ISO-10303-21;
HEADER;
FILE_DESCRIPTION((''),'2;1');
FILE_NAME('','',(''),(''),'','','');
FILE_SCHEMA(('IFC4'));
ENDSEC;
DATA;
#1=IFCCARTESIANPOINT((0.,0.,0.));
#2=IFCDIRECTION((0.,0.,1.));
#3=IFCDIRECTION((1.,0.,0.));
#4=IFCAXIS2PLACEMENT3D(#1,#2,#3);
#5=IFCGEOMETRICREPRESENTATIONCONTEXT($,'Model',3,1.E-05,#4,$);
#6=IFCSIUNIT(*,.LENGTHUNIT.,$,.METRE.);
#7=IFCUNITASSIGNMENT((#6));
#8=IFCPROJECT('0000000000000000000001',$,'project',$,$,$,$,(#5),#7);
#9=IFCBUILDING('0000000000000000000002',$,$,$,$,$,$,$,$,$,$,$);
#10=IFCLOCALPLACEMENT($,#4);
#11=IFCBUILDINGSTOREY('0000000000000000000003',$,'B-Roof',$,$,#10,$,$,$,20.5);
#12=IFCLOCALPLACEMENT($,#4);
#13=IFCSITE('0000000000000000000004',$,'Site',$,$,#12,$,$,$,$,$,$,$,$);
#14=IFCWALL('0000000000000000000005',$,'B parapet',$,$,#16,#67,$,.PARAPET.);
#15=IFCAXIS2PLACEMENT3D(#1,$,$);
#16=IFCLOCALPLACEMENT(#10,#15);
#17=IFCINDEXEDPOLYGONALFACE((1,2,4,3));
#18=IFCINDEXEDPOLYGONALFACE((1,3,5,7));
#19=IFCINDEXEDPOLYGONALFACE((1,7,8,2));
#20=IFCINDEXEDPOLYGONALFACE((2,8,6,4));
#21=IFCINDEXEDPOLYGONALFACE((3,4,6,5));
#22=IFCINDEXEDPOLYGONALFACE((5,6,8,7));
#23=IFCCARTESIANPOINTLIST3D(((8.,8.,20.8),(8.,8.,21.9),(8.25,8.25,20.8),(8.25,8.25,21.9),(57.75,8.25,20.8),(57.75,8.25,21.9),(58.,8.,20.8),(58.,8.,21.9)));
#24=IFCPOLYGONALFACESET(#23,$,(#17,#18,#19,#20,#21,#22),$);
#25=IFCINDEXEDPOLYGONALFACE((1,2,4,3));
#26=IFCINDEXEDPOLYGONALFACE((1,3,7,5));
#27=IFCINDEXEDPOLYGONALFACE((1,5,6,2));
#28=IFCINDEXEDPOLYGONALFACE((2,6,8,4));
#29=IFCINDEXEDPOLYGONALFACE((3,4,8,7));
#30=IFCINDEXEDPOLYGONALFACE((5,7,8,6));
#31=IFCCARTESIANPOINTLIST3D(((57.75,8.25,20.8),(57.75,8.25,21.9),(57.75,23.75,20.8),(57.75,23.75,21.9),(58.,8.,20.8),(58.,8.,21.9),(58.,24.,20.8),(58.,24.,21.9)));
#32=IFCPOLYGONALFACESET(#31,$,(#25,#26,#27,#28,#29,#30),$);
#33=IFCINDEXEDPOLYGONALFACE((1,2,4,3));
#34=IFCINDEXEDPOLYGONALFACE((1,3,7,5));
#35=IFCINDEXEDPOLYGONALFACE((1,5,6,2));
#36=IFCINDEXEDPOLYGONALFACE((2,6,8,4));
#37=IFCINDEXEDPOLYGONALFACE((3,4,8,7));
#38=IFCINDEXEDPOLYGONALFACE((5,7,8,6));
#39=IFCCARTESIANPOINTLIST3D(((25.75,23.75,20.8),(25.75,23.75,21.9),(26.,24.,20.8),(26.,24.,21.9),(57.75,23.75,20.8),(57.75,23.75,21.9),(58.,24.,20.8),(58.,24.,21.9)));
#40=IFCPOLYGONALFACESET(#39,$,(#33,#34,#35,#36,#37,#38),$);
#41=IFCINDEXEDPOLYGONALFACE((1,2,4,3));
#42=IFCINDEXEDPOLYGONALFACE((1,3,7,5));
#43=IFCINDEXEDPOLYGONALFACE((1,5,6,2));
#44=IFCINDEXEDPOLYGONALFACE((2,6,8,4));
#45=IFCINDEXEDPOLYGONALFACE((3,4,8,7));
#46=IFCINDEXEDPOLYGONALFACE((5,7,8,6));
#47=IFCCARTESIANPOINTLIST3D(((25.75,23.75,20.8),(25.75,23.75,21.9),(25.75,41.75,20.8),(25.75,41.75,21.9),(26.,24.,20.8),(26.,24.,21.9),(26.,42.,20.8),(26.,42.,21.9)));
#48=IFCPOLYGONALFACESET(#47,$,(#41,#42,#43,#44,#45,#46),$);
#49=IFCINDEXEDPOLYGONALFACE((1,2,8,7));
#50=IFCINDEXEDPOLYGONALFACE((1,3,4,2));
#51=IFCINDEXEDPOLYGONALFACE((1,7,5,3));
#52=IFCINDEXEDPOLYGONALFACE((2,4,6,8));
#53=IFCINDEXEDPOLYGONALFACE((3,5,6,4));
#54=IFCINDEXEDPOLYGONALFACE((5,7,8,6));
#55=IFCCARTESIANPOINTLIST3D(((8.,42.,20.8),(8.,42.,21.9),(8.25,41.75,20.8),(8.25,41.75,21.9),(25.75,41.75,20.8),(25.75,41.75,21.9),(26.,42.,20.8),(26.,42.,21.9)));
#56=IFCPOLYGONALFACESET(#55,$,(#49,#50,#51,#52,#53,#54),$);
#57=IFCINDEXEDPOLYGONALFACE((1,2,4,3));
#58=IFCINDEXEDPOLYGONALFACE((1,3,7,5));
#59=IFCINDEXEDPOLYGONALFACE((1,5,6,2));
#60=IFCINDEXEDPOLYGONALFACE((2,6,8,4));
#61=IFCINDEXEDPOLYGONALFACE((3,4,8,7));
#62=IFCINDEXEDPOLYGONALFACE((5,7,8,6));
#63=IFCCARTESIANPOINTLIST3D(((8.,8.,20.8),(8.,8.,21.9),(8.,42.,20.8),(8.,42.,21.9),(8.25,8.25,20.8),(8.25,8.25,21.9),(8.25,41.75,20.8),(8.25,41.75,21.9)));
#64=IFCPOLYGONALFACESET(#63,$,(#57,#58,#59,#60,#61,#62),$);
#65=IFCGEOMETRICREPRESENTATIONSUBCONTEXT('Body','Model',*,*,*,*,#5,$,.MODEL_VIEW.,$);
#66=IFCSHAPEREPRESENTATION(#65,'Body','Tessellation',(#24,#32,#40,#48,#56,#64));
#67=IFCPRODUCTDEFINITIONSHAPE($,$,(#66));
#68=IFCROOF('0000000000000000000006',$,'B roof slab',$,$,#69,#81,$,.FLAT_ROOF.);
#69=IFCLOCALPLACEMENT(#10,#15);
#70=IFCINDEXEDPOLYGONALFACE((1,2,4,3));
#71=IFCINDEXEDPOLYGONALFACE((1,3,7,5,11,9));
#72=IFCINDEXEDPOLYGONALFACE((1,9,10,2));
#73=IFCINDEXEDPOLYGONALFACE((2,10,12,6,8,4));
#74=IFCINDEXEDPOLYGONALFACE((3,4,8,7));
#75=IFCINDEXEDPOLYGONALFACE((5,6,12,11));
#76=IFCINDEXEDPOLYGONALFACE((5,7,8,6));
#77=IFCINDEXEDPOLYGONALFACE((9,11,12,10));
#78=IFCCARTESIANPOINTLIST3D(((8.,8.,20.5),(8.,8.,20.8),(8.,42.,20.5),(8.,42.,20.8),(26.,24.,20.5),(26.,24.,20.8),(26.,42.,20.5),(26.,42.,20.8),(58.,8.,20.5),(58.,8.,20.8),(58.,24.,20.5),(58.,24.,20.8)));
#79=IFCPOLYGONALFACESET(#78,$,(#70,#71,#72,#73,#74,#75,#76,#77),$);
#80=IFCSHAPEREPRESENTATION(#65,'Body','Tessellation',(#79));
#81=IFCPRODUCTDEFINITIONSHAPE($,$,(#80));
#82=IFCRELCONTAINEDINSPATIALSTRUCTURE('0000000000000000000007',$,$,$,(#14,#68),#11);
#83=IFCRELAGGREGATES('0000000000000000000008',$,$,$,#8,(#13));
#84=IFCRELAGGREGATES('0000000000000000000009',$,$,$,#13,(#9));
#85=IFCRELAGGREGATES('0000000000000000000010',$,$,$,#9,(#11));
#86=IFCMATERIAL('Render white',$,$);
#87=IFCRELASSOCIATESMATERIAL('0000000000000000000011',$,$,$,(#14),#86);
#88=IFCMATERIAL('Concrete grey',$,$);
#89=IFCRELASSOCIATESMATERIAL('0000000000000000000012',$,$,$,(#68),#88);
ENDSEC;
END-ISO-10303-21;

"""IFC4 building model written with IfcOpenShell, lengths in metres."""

from ifc_helpers import new_model, si_unit, frame, origin_with_axes, place, context, subcontext, project, spatial, polyline, outline, extrude, material, element, save


model = new_model("IFC4")

# Units and contexts
model_context = context("Model", 3, precision=1e-05, world=origin_with_axes())
body_context = subcontext(model_context, "Body", "Model", "MODEL_VIEW")
ifc_project = project(units=[si_unit("LENGTHUNIT", "METRE")], contexts=[model_context])

# Site, building, storey
site_placement = place(None, origin_with_axes())
site = spatial("IfcSite", under=ifc_project, at=site_placement, Name="Site")
building = spatial("IfcBuilding", under=site)
storey_placement = place(None, origin_with_axes())
storey = spatial("IfcBuildingStorey", under=building, at=storey_placement, Name="B-Roof", Elevation=20.5)

# Wall
ifc_material_1 = material(Name="Render white")
wall_placement = place(storey_placement, origin_with_axes())
element("IfcWall", 1, at=wall_placement, inside=storey, material=ifc_material_1, Name="B parapet", PredefinedType="PARAPET", context=body_context, shape_type="SweptSolid", body=[
    extrude(outline(polyline([(8.0, 8.0), (58.0, 8.0), (57.75, 8.25), (8.25, 8.25), (8.0, 8.0)])), frame((0.0, 0.0, 20.8), z_axis=(0.0, 0.0, 1.0), x_axis=(1.0, 0.0, 0.0)), (0.0, 0.0, 1.0), 1.1),
    extrude(outline(polyline([(58.0, 8.0), (58.0, 24.0), (57.75, 23.75), (57.75, 8.25), (58.0, 8.0)])), frame((0.0, 0.0, 20.8), z_axis=(0.0, 0.0, 1.0), x_axis=(1.0, 0.0, 0.0)), (0.0, 0.0, 1.0), 1.1),
    extrude(outline(polyline([(58.0, 24.0), (26.0, 24.0), (25.75, 23.75), (57.75, 23.75), (58.0, 24.0)])), frame((0.0, 0.0, 20.8), z_axis=(0.0, 0.0, 1.0), x_axis=(1.0, 0.0, 0.0)), (0.0, 0.0, 1.0), 1.1),
    extrude(outline(polyline([(26.0, 24.0), (26.0, 42.0), (25.75, 41.75), (25.75, 23.75), (26.0, 24.0)])), frame((0.0, 0.0, 20.8), z_axis=(0.0, 0.0, 1.0), x_axis=(1.0, 0.0, 0.0)), (0.0, 0.0, 1.0), 1.1),
    extrude(outline(polyline([(26.0, 42.0), (8.0, 42.0), (8.25, 41.75), (25.75, 41.75), (26.0, 42.0)])), frame((0.0, 0.0, 20.8), z_axis=(0.0, 0.0, 1.0), x_axis=(1.0, 0.0, 0.0)), (0.0, 0.0, 1.0), 1.1),
    extrude(outline(polyline([(8.0, 42.0), (8.0, 8.0), (8.25, 8.25), (8.25, 41.75), (8.0, 42.0)])), frame((0.0, 0.0, 20.8), z_axis=(0.0, 0.0, 1.0), x_axis=(1.0, 0.0, 0.0)), (0.0, 0.0, 1.0), 1.1),
])

# Roof
ifc_material_2 = material(Name="Concrete grey")
roof_placement = place(storey_placement, origin_with_axes())
element("IfcRoof", 2, at=roof_placement, inside=storey, material=ifc_material_2, Name="B roof slab", PredefinedType="FLAT_ROOF", context=body_context, shape_type="SweptSolid", body=[
    extrude(outline(polyline([(8.0, 8.0), (58.0, 8.0), (58.0, 24.0), (26.0, 24.0), (26.0, 42.0), (8.0, 42.0), (8.0, 8.0)])), frame((0.0, 0.0, 20.5), z_axis=(0.0, 0.0, 1.0), x_axis=(1.0, 0.0, 0.0)), (0.0, 0.0, 1.0), 0.3),
])

save(model, "model.ifc")
